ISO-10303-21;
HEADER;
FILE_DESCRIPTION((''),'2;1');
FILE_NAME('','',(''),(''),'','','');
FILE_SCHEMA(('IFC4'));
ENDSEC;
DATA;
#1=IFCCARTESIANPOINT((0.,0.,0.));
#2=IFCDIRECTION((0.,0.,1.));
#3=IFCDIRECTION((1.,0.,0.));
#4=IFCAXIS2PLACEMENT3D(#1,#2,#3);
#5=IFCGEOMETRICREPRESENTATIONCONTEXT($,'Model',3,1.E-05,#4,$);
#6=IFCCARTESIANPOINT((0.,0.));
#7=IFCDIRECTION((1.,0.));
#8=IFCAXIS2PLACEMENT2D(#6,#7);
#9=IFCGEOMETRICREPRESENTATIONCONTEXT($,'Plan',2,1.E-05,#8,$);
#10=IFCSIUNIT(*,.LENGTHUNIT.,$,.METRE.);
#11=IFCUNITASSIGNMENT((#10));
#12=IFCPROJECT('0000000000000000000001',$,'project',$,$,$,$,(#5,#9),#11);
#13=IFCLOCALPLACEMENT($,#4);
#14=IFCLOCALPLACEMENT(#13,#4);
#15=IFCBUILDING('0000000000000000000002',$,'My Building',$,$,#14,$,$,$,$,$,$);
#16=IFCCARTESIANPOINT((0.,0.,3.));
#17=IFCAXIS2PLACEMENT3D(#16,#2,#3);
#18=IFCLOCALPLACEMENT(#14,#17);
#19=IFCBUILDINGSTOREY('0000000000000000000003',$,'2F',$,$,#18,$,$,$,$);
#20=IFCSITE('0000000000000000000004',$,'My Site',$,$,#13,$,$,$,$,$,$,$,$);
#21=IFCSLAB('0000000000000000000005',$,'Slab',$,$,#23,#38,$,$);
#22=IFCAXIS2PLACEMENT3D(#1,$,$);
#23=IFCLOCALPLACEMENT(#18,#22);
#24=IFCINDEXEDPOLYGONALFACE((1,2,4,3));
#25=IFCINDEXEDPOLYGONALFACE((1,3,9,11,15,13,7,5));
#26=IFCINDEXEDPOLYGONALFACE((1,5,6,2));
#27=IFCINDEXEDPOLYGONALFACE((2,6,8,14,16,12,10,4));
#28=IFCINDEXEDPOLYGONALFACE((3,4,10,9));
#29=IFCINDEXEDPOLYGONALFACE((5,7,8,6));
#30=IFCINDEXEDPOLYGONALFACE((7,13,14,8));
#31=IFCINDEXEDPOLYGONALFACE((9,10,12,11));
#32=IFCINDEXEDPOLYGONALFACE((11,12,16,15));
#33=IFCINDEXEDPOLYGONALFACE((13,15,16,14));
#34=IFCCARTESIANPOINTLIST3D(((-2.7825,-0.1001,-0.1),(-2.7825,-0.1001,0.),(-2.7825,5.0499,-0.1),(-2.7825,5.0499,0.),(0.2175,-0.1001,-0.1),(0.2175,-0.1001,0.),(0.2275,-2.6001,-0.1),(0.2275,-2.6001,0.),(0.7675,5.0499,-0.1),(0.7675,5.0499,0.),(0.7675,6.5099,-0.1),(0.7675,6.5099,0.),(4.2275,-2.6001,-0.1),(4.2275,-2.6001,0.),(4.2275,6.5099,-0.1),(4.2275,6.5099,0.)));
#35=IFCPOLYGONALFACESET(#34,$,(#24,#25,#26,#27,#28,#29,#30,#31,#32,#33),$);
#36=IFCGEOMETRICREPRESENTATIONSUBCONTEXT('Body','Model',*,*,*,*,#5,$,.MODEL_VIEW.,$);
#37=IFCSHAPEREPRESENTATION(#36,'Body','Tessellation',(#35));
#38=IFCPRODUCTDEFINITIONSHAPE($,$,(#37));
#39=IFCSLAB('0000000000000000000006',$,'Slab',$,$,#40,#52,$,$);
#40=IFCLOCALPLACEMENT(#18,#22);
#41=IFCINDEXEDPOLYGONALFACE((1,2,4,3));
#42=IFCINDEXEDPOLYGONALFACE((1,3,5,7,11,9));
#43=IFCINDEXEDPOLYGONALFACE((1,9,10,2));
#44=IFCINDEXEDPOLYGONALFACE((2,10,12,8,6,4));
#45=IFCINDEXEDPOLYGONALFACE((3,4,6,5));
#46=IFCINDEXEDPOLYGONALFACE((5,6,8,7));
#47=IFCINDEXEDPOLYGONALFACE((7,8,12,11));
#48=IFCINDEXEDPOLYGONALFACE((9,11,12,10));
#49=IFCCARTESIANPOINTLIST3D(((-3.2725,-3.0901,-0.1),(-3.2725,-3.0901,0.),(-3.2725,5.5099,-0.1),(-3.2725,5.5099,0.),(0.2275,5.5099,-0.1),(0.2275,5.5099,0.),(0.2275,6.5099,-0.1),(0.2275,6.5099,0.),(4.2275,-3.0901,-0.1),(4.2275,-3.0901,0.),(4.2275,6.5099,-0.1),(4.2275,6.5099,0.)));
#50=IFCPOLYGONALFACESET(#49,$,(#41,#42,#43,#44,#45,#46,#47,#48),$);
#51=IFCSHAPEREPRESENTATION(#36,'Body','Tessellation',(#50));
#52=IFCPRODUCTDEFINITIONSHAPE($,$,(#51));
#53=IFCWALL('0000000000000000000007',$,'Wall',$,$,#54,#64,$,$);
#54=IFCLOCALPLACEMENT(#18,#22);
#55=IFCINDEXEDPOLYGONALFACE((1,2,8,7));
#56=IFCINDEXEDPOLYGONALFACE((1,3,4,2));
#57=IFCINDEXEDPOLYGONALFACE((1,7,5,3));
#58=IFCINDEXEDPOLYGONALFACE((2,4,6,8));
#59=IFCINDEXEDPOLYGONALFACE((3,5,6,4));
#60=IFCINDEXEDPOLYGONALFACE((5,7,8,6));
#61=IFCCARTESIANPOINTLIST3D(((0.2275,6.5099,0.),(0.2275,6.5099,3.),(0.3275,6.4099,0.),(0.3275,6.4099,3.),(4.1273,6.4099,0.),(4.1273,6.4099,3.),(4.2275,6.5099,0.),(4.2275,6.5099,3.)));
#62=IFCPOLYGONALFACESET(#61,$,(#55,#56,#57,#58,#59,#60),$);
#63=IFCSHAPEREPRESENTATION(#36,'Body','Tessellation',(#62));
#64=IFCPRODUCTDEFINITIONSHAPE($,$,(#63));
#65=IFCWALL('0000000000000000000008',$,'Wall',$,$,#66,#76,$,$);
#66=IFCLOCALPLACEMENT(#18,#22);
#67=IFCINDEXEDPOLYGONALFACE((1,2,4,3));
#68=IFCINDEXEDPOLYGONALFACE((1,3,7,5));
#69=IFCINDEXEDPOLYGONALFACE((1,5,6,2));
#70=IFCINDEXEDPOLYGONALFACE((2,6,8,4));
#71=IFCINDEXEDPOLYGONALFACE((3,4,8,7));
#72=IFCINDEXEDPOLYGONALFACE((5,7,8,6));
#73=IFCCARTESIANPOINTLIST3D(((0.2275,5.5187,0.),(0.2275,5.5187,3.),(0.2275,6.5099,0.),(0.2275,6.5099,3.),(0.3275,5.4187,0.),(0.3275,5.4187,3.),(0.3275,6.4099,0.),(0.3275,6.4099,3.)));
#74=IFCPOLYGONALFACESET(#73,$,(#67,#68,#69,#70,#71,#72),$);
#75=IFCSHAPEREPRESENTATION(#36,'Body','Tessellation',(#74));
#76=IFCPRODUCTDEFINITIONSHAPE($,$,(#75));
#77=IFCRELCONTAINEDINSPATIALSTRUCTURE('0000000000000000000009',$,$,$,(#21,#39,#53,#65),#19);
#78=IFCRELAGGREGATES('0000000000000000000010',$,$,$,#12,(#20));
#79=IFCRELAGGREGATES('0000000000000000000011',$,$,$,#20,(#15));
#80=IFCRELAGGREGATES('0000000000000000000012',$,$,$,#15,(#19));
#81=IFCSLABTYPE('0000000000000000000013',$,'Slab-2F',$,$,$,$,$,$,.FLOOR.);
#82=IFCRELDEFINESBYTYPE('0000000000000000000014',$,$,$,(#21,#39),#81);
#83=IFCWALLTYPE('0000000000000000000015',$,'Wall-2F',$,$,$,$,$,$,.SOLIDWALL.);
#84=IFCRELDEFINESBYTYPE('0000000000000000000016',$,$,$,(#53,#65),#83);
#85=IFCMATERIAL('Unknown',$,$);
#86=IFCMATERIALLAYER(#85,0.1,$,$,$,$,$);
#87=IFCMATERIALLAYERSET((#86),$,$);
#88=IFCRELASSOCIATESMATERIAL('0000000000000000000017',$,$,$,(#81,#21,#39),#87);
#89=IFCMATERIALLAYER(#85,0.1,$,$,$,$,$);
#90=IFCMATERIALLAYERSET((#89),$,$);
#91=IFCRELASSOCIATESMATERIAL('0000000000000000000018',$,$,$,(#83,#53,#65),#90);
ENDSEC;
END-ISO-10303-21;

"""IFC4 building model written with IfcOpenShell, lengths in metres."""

from ifc_helpers import new_model, si_unit, frame, origin_with_axes, origin_2d_with_axis, place, context, subcontext, project, spatial, line, indexed_curve, outline, extrude, material, layer, layer_set, layer_usage, type_object, element, save


model = new_model("IFC4")

# Units and contexts
model_context = context("Model", 3, precision=1e-05, world=origin_with_axes())
plan_context = context("Plan", 2, precision=1e-05, world=origin_2d_with_axis())
body_context_1 = subcontext(model_context, "Body", "Model", "MODEL_VIEW")
ifc_project = project(units=[si_unit("LENGTHUNIT", "METRE")], contexts=[model_context, plan_context])

# Site, building, storey
site_placement = place(None, origin_with_axes())
site = spatial("IfcSite", under=ifc_project, at=site_placement, Name="My Site")
building_placement = place(site_placement, origin_with_axes())
building = spatial("IfcBuilding", under=site, at=building_placement, Name="My Building")
storey_placement = place(building_placement, frame((0.0, 0.0, 3.0), z_axis=(0.0, 0.0, 1.0), x_axis=(1.0, 0.0, 0.0)))
storey = spatial("IfcBuildingStorey", under=building, at=storey_placement, Name="2F")

# Slabs
ifc_material = material(Name="Unknown")
ifc_layer_1 = layer(ifc_material, 0.1)
ifc_layer_set_1 = layer_set([ifc_layer_1])
ifc_layer_usage_1 = layer_usage(ifc_layer_set_1, "AXIS3", "POSITIVE", -0.1)
slab_type = type_object("IfcSlabType", Name="Slab-2F", PredefinedType="FLOOR", material=ifc_layer_set_1)
slab_1_placement = place(storey_placement, frame((4.2275, -2.6001, 0.0), z_axis=(0.0, 0.0, 1.0), x_axis=(1.0, 0.0, 0.0)))
element("IfcSlab", 1, at=slab_1_placement, inside=storey, type_object=slab_type, material=ifc_layer_usage_1, Name="Slab", context=body_context_1, shape_type="SweptSolid", body=[
    extrude(outline(indexed_curve([(0.0, 0.0), (0.0, 9.11), (-3.46, 9.11), (-3.46, 7.65), (-7.01, 7.65), (-7.01, 2.5), (-4.01, 2.5), (-4.0, 0.0), (0.0, 0.0)])), frame((0.0, 0.0, -0.1), z_axis=(0.0, 0.0, 1.0), x_axis=(1.0, 0.0, 0.0)), (0.0, 0.0, 1.0), 0.1),
])
ifc_layer_usage_2 = layer_usage(ifc_layer_set_1, "AXIS3", "POSITIVE", -0.1)
slab_2_placement = place(storey_placement, frame((4.2275, 6.5099, 0.0), z_axis=(0.0, 0.0, 1.0), x_axis=(1.0, 0.0, 0.0)))
element("IfcSlab", 2, at=slab_2_placement, inside=storey, type_object=slab_type, material=ifc_layer_usage_2, Name="Slab", context=body_context_1, shape_type="SweptSolid", body=[
    extrude(outline(indexed_curve([(0.0, 0.0), (-4.0, 0.0), (-4.0, -1.0), (-7.5, -1.0), (-7.5, -9.6), (0.0, -9.6), (0.0, 0.0)])), frame((0.0, 0.0, -0.1), z_axis=(0.0, 0.0, 1.0), x_axis=(1.0, 0.0, 0.0)), (0.0, 0.0, 1.0), 0.1),
])

# Walls
ifc_layer_2 = layer(ifc_material, 0.1)
ifc_layer_set_2 = layer_set([ifc_layer_2])
ifc_layer_usage_3 = layer_usage(ifc_layer_set_2, "AXIS2", "POSITIVE", 0.0)
wall_type = type_object("IfcWallType", Name="Wall-2F", PredefinedType="SOLIDWALL", material=ifc_layer_set_2)
wall_1_placement = place(storey_placement, frame((4.2275, 6.5099, 0.0), z_axis=(0.0, 0.0, 1.0), x_axis=(-1.0, 0.0, 0.0)))
element("IfcWall", 3, at=wall_1_placement, inside=storey, type_object=wall_type, material=ifc_layer_usage_3, Name="Wall", context=body_context_1, shape_type="SweptSolid", body=[
    extrude(outline(indexed_curve([(0.0, 0.0), (0.1002, 0.1), (3.9, 0.1), (4.0, 0.0)], segments=[line(1, 2, 3, 4, 1)])), origin_with_axes(), (0.0, 0.0, 1.0), 3.0),
])
ifc_layer_usage_4 = layer_usage(ifc_layer_set_2, "AXIS2", "POSITIVE", 0.0)
wall_2_placement = place(storey_placement, frame((0.2275, 6.5099, 0.0), z_axis=(0.0, 0.0, 1.0), x_axis=(0.0, -1.0, 0.0)))
element("IfcWall", 4, at=wall_2_placement, inside=storey, type_object=wall_type, material=ifc_layer_usage_4, Name="Wall", context=body_context_1, shape_type="SweptSolid", body=[
    extrude(outline(indexed_curve([(0.0, 0.0), (0.1, 0.1), (1.0913, 0.1), (0.9913, 0.0)], segments=[line(1, 2, 3, 4, 1)])), origin_with_axes(), (0.0, 0.0, 1.0), 3.0),
])

save(model, "model.ifc")
